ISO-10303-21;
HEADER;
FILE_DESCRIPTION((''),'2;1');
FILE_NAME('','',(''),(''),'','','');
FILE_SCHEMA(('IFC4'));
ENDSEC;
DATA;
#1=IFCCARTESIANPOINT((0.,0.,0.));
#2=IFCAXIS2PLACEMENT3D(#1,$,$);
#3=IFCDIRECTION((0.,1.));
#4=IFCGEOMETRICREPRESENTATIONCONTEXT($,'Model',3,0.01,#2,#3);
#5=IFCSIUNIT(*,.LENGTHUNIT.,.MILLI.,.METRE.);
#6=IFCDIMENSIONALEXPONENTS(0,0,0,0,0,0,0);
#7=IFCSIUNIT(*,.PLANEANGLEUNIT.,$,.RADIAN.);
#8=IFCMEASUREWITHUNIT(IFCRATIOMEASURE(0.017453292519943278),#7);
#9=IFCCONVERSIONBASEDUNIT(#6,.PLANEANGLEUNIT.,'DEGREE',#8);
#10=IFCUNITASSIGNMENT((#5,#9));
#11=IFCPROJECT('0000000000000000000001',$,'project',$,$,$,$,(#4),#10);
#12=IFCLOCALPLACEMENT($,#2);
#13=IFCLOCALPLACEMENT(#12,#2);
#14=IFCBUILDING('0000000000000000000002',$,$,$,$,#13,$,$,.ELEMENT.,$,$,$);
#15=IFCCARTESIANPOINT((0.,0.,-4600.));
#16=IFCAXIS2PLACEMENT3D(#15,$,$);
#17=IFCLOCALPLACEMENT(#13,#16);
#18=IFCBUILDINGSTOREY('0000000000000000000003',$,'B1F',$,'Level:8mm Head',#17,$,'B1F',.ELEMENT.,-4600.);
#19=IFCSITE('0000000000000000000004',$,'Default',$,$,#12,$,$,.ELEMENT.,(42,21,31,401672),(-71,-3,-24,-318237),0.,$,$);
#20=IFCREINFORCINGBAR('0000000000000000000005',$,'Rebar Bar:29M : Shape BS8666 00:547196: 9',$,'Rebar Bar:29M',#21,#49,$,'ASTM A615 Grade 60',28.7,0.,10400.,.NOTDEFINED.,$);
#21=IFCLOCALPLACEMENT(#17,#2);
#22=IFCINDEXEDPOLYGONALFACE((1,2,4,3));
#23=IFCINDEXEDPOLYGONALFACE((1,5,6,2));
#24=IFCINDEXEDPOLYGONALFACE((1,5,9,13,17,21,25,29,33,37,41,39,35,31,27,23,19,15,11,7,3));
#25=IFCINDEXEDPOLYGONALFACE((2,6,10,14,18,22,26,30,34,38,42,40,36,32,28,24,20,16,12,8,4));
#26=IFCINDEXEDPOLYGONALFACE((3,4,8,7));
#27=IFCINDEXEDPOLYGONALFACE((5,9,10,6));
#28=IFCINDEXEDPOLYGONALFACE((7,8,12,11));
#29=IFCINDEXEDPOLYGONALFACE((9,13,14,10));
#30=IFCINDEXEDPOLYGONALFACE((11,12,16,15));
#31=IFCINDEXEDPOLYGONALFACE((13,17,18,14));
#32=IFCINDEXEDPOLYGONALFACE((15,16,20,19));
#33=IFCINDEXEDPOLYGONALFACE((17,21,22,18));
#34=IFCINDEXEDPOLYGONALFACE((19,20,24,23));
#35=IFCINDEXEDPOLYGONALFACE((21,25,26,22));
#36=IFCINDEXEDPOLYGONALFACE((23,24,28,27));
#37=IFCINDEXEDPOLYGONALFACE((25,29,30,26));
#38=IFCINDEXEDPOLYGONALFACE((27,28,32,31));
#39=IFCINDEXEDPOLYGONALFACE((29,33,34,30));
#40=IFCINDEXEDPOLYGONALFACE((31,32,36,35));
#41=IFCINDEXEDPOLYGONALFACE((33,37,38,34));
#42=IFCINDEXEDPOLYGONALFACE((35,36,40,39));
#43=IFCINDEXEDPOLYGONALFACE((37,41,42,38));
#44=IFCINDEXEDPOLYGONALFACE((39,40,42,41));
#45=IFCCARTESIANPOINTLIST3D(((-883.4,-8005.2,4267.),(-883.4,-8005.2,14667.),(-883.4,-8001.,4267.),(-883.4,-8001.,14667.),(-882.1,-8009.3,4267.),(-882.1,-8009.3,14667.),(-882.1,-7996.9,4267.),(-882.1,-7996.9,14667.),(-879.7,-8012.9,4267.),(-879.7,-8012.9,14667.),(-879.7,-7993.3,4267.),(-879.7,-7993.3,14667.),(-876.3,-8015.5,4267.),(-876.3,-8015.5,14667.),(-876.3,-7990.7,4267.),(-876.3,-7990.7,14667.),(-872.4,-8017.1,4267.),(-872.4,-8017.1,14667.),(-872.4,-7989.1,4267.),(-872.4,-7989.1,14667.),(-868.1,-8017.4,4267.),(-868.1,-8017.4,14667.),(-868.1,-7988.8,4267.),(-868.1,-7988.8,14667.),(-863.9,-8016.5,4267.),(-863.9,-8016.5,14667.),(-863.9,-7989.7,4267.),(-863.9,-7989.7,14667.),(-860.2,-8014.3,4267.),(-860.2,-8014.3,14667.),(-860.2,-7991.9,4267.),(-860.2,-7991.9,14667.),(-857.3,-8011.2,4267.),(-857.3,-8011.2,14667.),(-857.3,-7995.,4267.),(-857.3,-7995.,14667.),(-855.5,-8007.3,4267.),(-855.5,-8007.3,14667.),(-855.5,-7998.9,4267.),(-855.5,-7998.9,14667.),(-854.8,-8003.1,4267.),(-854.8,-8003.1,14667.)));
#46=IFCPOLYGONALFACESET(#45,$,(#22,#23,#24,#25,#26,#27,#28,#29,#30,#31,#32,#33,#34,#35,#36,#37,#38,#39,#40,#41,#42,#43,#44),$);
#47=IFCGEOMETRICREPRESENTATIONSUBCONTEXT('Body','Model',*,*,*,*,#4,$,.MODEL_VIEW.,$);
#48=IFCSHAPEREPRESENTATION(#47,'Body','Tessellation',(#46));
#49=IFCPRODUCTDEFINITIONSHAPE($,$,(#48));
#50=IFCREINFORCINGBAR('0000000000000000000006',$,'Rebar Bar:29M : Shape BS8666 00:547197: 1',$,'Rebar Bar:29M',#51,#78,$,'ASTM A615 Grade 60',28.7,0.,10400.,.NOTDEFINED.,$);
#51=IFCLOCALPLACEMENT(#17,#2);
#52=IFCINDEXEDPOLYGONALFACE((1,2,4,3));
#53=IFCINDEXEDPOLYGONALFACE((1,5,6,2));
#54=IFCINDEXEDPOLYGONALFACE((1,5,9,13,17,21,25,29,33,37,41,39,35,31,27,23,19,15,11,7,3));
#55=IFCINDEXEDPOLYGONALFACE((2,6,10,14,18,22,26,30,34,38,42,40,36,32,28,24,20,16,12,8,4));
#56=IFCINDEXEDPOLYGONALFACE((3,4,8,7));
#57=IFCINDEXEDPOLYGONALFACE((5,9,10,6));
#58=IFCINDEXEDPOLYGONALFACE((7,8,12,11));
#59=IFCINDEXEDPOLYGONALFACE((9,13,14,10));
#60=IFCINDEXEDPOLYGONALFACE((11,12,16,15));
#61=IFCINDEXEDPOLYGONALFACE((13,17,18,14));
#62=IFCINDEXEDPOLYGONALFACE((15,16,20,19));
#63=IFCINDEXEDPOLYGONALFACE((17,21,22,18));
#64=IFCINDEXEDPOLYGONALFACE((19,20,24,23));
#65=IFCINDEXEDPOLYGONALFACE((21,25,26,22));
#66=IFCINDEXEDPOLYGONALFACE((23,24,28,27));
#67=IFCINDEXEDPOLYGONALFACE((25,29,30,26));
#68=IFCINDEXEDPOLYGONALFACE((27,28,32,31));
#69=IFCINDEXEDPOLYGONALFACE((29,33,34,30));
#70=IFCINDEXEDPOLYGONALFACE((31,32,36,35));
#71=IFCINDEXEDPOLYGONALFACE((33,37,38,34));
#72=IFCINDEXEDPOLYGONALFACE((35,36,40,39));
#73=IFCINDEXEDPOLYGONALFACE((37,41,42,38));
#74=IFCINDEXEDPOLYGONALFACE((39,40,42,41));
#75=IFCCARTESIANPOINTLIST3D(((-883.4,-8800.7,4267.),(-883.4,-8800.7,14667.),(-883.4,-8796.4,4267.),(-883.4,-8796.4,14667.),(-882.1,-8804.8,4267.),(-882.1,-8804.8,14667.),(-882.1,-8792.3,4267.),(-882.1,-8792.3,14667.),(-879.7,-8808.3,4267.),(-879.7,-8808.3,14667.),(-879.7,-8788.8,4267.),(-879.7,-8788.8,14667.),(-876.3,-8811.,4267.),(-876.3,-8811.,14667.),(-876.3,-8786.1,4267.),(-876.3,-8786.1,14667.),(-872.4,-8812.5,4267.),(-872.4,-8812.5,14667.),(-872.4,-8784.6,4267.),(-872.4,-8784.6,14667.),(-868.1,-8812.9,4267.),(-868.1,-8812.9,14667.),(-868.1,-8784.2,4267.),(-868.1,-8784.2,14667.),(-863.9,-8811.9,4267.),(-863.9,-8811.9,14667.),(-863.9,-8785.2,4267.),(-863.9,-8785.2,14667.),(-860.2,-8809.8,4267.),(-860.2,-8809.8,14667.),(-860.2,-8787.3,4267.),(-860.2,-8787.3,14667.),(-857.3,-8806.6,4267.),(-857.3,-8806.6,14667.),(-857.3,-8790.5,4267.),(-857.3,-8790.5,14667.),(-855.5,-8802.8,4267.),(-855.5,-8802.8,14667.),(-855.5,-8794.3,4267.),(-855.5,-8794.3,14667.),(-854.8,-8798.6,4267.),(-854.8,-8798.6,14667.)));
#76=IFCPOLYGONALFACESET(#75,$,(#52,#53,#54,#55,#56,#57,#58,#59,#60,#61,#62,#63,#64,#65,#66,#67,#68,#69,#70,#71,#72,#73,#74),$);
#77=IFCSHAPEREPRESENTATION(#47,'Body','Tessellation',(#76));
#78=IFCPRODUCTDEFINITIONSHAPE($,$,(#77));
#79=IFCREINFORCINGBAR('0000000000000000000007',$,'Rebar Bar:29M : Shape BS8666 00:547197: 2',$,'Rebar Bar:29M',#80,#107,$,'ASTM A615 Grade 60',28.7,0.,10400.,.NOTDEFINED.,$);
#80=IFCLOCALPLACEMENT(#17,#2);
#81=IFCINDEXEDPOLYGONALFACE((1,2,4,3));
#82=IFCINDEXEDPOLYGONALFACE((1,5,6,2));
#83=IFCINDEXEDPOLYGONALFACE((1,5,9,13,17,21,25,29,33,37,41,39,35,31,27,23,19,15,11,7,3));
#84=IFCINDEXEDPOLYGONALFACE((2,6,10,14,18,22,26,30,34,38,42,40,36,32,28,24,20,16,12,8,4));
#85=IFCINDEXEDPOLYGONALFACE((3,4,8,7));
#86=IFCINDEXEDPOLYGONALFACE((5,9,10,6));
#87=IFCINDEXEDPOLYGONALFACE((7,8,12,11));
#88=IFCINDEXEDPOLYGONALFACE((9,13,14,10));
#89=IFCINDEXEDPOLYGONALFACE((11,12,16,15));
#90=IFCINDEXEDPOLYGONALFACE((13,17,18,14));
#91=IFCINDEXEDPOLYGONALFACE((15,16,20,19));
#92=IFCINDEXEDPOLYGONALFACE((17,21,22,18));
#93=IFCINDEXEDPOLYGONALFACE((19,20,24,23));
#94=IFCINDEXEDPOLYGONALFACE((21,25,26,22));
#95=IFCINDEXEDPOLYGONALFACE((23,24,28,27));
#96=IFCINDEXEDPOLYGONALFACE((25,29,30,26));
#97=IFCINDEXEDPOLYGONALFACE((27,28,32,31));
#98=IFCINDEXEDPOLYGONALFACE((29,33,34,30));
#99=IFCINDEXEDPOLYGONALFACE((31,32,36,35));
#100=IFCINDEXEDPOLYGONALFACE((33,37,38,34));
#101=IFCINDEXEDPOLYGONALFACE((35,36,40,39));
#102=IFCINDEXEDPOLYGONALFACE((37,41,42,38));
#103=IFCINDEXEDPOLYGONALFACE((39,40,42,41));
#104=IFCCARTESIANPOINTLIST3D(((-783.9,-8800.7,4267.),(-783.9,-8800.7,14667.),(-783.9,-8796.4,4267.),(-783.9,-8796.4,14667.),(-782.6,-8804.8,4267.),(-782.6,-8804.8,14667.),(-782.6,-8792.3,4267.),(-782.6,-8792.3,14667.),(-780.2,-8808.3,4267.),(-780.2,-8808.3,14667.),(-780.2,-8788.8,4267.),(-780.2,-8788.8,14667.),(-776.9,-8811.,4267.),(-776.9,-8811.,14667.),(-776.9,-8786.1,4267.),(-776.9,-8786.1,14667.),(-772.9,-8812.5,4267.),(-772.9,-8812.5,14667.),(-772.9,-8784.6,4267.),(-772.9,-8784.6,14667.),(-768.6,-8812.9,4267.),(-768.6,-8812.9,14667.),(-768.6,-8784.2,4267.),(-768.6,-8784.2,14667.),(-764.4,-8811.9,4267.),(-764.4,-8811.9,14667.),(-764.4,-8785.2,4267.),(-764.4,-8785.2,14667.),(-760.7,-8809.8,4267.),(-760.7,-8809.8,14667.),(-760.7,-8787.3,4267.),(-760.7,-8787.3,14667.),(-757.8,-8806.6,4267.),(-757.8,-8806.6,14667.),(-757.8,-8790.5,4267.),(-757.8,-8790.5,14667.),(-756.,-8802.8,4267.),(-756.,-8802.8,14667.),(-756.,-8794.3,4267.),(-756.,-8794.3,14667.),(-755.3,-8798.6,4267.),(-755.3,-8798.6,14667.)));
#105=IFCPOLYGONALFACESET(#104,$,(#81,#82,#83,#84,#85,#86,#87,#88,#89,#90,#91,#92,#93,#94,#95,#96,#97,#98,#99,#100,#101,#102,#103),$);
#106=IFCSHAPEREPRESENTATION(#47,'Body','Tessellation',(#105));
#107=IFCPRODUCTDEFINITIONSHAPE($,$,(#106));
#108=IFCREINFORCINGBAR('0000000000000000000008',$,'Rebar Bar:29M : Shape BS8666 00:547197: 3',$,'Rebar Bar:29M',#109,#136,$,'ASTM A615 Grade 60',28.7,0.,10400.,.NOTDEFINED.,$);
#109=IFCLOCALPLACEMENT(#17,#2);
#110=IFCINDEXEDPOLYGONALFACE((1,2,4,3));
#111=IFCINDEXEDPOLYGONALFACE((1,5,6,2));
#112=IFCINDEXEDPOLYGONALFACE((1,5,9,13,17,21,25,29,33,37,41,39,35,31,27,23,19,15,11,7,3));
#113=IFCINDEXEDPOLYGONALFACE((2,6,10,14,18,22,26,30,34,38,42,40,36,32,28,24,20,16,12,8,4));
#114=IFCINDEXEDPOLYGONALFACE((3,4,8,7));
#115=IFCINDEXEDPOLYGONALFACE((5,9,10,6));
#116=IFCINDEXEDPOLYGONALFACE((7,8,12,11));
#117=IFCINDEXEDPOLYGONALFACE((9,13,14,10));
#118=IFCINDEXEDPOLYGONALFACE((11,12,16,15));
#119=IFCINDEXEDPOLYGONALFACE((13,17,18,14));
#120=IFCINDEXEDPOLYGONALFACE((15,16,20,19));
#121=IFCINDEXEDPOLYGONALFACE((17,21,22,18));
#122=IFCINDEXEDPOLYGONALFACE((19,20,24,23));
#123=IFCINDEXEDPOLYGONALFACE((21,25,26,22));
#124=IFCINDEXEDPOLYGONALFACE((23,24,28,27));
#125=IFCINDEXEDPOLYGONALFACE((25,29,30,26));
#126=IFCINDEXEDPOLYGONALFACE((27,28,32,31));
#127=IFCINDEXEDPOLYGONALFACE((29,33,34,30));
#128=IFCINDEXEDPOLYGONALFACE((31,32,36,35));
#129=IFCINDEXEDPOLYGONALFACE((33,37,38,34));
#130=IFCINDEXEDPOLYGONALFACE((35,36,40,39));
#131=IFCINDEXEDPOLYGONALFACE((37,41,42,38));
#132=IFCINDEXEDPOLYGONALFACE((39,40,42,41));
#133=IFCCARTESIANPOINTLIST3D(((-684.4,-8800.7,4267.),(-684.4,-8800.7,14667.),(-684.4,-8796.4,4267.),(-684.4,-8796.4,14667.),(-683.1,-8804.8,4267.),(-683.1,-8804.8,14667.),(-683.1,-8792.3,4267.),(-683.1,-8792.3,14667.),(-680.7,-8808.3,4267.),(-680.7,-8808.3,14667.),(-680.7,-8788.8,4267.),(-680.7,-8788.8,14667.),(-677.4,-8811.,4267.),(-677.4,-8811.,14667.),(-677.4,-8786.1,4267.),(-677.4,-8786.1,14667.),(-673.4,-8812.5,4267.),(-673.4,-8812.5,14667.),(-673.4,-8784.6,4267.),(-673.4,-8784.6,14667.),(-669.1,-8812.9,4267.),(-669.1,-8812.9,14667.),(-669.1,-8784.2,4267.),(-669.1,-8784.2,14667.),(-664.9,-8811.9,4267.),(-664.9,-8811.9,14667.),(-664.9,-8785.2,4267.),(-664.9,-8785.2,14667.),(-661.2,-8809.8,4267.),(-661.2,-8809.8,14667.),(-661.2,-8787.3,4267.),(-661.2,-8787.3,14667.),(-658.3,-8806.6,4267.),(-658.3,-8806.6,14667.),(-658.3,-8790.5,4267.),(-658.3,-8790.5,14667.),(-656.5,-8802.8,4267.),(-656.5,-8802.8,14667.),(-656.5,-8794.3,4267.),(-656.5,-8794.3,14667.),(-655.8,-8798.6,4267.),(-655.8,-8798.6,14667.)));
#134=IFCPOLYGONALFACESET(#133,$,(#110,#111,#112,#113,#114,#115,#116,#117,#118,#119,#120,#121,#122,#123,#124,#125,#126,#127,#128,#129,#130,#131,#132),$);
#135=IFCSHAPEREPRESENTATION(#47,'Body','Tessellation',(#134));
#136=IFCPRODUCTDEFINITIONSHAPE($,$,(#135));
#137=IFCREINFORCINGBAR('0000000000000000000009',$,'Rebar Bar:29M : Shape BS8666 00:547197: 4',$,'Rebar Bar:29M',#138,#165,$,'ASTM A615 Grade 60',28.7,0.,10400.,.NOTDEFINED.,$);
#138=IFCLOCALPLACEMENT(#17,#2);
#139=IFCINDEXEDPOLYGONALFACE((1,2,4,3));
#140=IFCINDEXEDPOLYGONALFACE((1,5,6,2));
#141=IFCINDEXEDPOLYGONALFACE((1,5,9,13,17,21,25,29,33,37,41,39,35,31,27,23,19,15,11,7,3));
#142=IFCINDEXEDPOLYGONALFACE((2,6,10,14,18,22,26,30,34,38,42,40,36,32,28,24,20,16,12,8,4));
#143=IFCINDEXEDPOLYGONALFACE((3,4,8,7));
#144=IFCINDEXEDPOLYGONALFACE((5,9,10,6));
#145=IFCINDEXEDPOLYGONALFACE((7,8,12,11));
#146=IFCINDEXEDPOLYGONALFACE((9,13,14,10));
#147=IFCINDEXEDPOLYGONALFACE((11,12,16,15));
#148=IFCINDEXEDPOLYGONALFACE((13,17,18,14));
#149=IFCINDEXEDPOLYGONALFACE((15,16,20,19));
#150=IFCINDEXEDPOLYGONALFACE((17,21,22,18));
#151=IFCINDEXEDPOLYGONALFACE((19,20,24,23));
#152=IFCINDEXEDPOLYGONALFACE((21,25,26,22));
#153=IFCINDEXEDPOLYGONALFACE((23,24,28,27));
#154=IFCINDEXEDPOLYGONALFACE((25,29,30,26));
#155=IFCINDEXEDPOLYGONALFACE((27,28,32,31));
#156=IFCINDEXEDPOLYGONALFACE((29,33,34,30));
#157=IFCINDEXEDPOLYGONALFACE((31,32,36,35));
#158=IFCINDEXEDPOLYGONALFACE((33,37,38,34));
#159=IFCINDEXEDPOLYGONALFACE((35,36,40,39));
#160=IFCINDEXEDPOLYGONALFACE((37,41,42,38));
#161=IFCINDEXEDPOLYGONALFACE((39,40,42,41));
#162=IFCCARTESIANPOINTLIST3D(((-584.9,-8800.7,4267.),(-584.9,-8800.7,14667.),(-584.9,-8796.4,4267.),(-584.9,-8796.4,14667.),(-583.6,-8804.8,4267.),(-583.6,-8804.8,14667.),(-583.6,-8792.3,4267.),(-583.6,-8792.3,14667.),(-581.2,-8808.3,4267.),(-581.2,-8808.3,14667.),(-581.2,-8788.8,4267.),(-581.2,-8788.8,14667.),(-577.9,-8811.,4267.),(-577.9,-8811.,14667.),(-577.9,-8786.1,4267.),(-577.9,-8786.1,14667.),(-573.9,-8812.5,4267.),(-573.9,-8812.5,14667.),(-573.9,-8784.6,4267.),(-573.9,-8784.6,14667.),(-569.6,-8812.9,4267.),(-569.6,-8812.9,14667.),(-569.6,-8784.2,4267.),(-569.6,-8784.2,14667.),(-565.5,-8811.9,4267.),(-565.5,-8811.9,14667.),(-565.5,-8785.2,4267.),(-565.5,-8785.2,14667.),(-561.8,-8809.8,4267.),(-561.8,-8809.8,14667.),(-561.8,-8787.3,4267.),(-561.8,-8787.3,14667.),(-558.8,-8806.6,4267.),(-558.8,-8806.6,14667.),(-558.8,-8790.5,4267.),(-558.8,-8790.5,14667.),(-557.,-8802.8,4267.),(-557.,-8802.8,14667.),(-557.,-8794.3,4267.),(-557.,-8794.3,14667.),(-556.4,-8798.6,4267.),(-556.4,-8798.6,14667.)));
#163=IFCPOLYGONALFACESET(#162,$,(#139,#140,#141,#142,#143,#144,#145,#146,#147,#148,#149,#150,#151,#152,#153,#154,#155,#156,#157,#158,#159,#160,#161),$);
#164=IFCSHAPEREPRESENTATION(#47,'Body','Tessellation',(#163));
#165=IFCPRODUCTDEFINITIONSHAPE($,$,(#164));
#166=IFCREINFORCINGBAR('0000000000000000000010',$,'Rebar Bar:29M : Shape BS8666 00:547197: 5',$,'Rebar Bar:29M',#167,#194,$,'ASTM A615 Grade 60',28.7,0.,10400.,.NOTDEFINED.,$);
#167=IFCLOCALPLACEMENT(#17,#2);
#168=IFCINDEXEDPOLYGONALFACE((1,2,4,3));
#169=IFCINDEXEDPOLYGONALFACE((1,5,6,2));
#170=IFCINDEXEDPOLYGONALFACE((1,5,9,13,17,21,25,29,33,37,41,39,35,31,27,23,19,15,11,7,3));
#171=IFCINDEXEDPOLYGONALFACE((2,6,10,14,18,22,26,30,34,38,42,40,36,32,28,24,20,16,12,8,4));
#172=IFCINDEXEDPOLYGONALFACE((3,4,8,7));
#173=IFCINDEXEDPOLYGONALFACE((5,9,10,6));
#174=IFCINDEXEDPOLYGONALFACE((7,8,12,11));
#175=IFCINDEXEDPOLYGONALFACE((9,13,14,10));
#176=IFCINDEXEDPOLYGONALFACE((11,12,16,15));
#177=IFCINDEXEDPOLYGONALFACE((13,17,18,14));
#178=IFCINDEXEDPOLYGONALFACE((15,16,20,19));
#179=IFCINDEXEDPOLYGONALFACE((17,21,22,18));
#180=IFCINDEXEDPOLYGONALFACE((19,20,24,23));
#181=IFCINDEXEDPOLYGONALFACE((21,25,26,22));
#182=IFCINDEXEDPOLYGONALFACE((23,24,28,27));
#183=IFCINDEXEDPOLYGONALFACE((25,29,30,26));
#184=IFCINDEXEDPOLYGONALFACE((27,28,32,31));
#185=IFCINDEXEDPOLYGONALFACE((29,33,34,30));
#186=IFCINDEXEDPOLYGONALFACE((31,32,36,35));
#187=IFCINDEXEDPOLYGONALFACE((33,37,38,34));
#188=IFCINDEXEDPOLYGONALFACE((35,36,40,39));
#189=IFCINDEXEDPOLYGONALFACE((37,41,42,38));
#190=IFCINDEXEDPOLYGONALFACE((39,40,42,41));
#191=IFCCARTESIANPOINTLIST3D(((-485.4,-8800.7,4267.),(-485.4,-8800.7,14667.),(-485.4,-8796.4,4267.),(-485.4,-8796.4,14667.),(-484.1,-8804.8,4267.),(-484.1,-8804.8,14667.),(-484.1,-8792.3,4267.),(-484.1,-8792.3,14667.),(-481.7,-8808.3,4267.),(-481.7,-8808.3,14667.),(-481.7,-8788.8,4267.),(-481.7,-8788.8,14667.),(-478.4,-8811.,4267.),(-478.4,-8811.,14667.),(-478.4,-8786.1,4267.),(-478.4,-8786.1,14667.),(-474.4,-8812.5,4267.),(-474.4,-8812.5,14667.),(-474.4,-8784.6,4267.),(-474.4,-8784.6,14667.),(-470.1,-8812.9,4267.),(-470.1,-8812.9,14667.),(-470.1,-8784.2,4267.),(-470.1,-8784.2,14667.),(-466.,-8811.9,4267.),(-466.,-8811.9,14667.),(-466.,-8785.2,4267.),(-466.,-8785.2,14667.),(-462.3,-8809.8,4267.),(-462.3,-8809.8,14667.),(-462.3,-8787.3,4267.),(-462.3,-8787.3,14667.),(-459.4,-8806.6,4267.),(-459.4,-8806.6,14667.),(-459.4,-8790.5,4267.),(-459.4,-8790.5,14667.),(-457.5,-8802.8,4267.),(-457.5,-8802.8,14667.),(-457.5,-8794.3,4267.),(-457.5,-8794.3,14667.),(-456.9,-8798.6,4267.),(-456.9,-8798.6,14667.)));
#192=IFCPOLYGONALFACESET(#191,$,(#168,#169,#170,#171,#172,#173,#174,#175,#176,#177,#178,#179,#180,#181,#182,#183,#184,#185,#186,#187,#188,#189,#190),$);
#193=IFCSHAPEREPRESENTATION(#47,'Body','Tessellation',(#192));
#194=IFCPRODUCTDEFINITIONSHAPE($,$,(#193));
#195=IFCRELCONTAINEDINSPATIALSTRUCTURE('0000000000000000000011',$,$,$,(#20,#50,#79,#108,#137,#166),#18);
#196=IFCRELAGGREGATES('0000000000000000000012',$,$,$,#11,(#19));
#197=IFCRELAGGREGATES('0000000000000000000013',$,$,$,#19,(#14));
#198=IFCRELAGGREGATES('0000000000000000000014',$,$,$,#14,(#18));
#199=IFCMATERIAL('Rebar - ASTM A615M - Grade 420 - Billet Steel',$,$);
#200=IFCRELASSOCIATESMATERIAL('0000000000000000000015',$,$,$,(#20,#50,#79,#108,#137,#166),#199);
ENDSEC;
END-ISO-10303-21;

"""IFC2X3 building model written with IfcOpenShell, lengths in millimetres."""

from ifc_helpers import new_model, entity, si_unit, converted_unit, direction, frame, origin, place, context, subcontext, project, spatial, material, element, save


model = new_model("IFC2X3")

# Units and contexts
model_context = context("Model", 3, precision=0.01, world=origin(), true_north=direction((0.0, 1.0)))
body_context = subcontext(model_context, "Body", "Model", "MODEL_VIEW")
ifc_project = project(units=[si_unit("LENGTHUNIT", "METRE", prefix="MILLI"), converted_unit("PLANEANGLEUNIT", "DEGREE", entity("IfcRatioMeasure", 0.017453292519943278), si_unit("PLANEANGLEUNIT", "RADIAN"), dimensions=[0, 0, 0, 0, 0, 0, 0])], contexts=[model_context])

# Site, building, storey
site_placement = place(None, origin())
site = spatial("IfcSite", under=ifc_project, at=site_placement, Name="Default", CompositionType="ELEMENT", RefLatitude=(42, 21, 31, 401672), RefLongitude=(-71, -3, -24, -318237), RefElevation=0.0)
building_placement = place(site_placement, origin())
building = spatial("IfcBuilding", under=site, at=building_placement, CompositionType="ELEMENT")
storey_placement = place(building_placement, frame((0.0, 0.0, -4600.0)))
storey = spatial("IfcBuildingStorey", under=building, at=storey_placement, Name="B1F", ObjectType="Level:8mm Head", LongName="B1F", CompositionType="ELEMENT", Elevation=-4600.0)

# Reinforcing bars
ifc_material = material(Name="Rebar - ASTM A615M - Grade 420 - Billet Steel")
reinforcing_bar_1_placement = place(storey_placement, origin())
element("IfcReinforcingBar", 1, at=reinforcing_bar_1_placement, inside=storey, material=ifc_material, Name="Rebar Bar:29M : Shape BS8666 00:547196: 9", SteelGrade="ASTM A615 Grade 60", ObjectType="Rebar Bar:29M", BarLength=10400.0, BarRole="NOTDEFINED", CrossSectionArea=0.0, NominalDiameter=28.7, context=body_context, shape_type="AdvancedSweptSolid", body=[
    entity("IfcSweptDiskSolid", entity("IfcCompositeCurve", [entity("IfcCompositeCurveSegment", "CONTINUOUS", True, entity("IfcPolyline", [entity("IfcCartesianPoint", [-869.2, -8003.1, 4267.0]), entity("IfcCartesianPoint", [-869.2, -8003.1, 14667.0])]))], False), 14.3, None, 0.0, 1.0),
])
reinforcing_bar_2_placement = place(storey_placement, origin())
element("IfcReinforcingBar", 2, at=reinforcing_bar_2_placement, inside=storey, material=ifc_material, Name="Rebar Bar:29M : Shape BS8666 00:547197: 1", SteelGrade="ASTM A615 Grade 60", ObjectType="Rebar Bar:29M", BarLength=10400.0, BarRole="NOTDEFINED", CrossSectionArea=0.0, NominalDiameter=28.7, context=body_context, shape_type="AdvancedSweptSolid", body=[
    entity("IfcSweptDiskSolid", entity("IfcCompositeCurve", [entity("IfcCompositeCurveSegment", "CONTINUOUS", True, entity("IfcPolyline", [entity("IfcCartesianPoint", [-869.2, -8798.6, 4267.0]), entity("IfcCartesianPoint", [-869.2, -8798.6, 14667.0])]))], False), 14.3, None, 0.0, 1.0),
])
reinforcing_bar_3_placement = place(storey_placement, origin())
element("IfcReinforcingBar", 3, at=reinforcing_bar_3_placement, inside=storey, material=ifc_material, Name="Rebar Bar:29M : Shape BS8666 00:547197: 2", SteelGrade="ASTM A615 Grade 60", ObjectType="Rebar Bar:29M", BarLength=10400.0, BarRole="NOTDEFINED", CrossSectionArea=0.0, NominalDiameter=28.7, context=body_context, shape_type="AdvancedSweptSolid", body=[
    entity("IfcSweptDiskSolid", entity("IfcCompositeCurve", [entity("IfcCompositeCurveSegment", "CONTINUOUS", True, entity("IfcPolyline", [entity("IfcCartesianPoint", [-769.7, -8798.6, 4267.0]), entity("IfcCartesianPoint", [-769.7, -8798.6, 14667.0])]))], False), 14.3, None, 0.0, 1.0),
])
reinforcing_bar_4_placement = place(storey_placement, origin())
element("IfcReinforcingBar", 4, at=reinforcing_bar_4_placement, inside=storey, material=ifc_material, Name="Rebar Bar:29M : Shape BS8666 00:547197: 3", SteelGrade="ASTM A615 Grade 60", ObjectType="Rebar Bar:29M", BarLength=10400.0, BarRole="NOTDEFINED", CrossSectionArea=0.0, NominalDiameter=28.7, context=body_context, shape_type="AdvancedSweptSolid", body=[
    entity("IfcSweptDiskSolid", entity("IfcCompositeCurve", [entity("IfcCompositeCurveSegment", "CONTINUOUS", True, entity("IfcPolyline", [entity("IfcCartesianPoint", [-670.2, -8798.6, 4267.0]), entity("IfcCartesianPoint", [-670.2, -8798.6, 14667.0])]))], False), 14.3, None, 0.0, 1.0),
])
reinforcing_bar_5_placement = place(storey_placement, origin())
element("IfcReinforcingBar", 5, at=reinforcing_bar_5_placement, inside=storey, material=ifc_material, Name="Rebar Bar:29M : Shape BS8666 00:547197: 4", SteelGrade="ASTM A615 Grade 60", ObjectType="Rebar Bar:29M", BarLength=10400.0, BarRole="NOTDEFINED", CrossSectionArea=0.0, NominalDiameter=28.7, context=body_context, shape_type="AdvancedSweptSolid", body=[
    entity("IfcSweptDiskSolid", entity("IfcCompositeCurve", [entity("IfcCompositeCurveSegment", "CONTINUOUS", True, entity("IfcPolyline", [entity("IfcCartesianPoint", [-570.7, -8798.6, 4267.0]), entity("IfcCartesianPoint", [-570.7, -8798.6, 14667.0])]))], False), 14.3, None, 0.0, 1.0),
])
reinforcing_bar_6_placement = place(storey_placement, origin())
element("IfcReinforcingBar", 6, at=reinforcing_bar_6_placement, inside=storey, material=ifc_material, Name="Rebar Bar:29M : Shape BS8666 00:547197: 5", SteelGrade="ASTM A615 Grade 60", ObjectType="Rebar Bar:29M", BarLength=10400.0, BarRole="NOTDEFINED", CrossSectionArea=0.0, NominalDiameter=28.7, context=body_context, shape_type="AdvancedSweptSolid", body=[
    entity("IfcSweptDiskSolid", entity("IfcCompositeCurve", [entity("IfcCompositeCurveSegment", "CONTINUOUS", True, entity("IfcPolyline", [entity("IfcCartesianPoint", [-471.2, -8798.6, 4267.0]), entity("IfcCartesianPoint", [-471.2, -8798.6, 14667.0])]))], False), 14.3, None, 0.0, 1.0),
])

save(model, "model.ifc")
